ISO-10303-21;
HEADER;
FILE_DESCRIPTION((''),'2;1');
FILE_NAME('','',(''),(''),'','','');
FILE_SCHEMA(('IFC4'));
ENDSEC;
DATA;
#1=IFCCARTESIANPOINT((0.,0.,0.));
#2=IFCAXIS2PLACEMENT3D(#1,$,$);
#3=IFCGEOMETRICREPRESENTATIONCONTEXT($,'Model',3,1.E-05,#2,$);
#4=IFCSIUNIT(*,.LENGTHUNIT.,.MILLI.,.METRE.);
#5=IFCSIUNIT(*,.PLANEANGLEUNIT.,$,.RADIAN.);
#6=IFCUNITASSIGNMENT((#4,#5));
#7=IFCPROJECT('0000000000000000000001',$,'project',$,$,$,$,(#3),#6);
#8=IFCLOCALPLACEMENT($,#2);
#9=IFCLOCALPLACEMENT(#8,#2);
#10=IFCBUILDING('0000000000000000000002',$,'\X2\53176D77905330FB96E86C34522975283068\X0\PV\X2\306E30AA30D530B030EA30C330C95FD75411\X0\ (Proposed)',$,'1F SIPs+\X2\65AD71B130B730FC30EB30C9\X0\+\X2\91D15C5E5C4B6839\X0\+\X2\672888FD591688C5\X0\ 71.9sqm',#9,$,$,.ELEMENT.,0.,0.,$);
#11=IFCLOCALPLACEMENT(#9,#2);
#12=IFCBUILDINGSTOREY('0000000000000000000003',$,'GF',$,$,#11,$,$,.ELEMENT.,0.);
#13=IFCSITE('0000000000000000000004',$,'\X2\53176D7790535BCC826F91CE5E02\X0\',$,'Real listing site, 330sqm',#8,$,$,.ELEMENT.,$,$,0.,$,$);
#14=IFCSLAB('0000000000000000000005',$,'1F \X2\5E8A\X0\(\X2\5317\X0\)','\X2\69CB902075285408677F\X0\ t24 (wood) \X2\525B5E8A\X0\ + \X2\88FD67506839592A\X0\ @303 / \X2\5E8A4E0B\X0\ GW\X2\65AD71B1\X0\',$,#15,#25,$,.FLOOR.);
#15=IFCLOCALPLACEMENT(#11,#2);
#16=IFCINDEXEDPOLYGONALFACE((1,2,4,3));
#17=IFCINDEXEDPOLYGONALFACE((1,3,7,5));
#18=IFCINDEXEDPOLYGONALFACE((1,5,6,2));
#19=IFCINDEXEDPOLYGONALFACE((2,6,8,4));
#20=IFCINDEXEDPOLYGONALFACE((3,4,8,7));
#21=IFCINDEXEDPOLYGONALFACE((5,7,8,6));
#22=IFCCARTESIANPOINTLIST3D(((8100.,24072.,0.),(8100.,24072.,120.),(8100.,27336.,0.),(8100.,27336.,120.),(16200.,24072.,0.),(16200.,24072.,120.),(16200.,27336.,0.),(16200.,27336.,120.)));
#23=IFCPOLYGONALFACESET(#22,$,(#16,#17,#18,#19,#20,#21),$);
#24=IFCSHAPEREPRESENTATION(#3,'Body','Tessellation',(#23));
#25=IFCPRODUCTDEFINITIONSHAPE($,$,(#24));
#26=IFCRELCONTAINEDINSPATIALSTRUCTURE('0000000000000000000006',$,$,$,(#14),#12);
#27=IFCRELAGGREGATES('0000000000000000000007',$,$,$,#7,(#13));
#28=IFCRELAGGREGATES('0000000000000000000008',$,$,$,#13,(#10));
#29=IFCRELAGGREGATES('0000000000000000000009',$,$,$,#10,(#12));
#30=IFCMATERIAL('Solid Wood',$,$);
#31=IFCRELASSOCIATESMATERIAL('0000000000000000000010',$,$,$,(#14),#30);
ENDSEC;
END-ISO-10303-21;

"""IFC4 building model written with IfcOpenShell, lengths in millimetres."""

from ifc_helpers import new_model, si_unit, frame, frame_2d, origin, place, context, project, spatial, rectangle, extrude, material, element, save


model = new_model("IFC4")

# Units and contexts
model_context = context("Model", 3, precision=1e-05, world=origin())
ifc_project = project(units=[si_unit("LENGTHUNIT", "METRE", prefix="MILLI"), si_unit("PLANEANGLEUNIT", "RADIAN")], contexts=[model_context])

# Site, building, storey
site_placement = place(None, origin())
site = spatial("IfcSite", under=ifc_project, at=site_placement, Name="北海道富良野市", ObjectType="Real listing site, 330sqm", CompositionType="ELEMENT", RefElevation=0.0)
building_placement = place(site_placement, origin())
building = spatial("IfcBuilding", under=site, at=building_placement, Name="北海道・雨水利用とPVのオフグリッド志向 (Proposed)", ObjectType="1F SIPs+断熱シールド+金属屋根+木製外装 71.9sqm", CompositionType="ELEMENT", ElevationOfRefHeight=0.0, ElevationOfTerrain=0.0)
storey_placement = place(building_placement, origin())
storey = spatial("IfcBuildingStorey", under=building, at=storey_placement, Name="GF", CompositionType="ELEMENT", Elevation=0.0)

# Shared definitions
ifc_material_1 = material(Name="Solid Wood")

# Slab
slab_1_placement = place(storey_placement, frame((4050.0, 12036.0, 0.0)))
element("IfcSlab", 1, at=slab_1_placement, inside=storey, material=ifc_material_1, Name="1F 床(北)", Description="構造用合板 t24 (wood) 剛床 + 製材根太 @303 / 床下 GW断熱", PredefinedType="FLOOR", context=model_context, shape_type="SweptSolid", body=[
    extrude(rectangle(XDim=8100.0, YDim=3264.0, at=frame_2d((4050.0, 1632.0))), frame((4050.0, 12036.0, 0.0)), (0.0, 0.0, 1.0), 120.0),
])

save(model, "model.ifc")
